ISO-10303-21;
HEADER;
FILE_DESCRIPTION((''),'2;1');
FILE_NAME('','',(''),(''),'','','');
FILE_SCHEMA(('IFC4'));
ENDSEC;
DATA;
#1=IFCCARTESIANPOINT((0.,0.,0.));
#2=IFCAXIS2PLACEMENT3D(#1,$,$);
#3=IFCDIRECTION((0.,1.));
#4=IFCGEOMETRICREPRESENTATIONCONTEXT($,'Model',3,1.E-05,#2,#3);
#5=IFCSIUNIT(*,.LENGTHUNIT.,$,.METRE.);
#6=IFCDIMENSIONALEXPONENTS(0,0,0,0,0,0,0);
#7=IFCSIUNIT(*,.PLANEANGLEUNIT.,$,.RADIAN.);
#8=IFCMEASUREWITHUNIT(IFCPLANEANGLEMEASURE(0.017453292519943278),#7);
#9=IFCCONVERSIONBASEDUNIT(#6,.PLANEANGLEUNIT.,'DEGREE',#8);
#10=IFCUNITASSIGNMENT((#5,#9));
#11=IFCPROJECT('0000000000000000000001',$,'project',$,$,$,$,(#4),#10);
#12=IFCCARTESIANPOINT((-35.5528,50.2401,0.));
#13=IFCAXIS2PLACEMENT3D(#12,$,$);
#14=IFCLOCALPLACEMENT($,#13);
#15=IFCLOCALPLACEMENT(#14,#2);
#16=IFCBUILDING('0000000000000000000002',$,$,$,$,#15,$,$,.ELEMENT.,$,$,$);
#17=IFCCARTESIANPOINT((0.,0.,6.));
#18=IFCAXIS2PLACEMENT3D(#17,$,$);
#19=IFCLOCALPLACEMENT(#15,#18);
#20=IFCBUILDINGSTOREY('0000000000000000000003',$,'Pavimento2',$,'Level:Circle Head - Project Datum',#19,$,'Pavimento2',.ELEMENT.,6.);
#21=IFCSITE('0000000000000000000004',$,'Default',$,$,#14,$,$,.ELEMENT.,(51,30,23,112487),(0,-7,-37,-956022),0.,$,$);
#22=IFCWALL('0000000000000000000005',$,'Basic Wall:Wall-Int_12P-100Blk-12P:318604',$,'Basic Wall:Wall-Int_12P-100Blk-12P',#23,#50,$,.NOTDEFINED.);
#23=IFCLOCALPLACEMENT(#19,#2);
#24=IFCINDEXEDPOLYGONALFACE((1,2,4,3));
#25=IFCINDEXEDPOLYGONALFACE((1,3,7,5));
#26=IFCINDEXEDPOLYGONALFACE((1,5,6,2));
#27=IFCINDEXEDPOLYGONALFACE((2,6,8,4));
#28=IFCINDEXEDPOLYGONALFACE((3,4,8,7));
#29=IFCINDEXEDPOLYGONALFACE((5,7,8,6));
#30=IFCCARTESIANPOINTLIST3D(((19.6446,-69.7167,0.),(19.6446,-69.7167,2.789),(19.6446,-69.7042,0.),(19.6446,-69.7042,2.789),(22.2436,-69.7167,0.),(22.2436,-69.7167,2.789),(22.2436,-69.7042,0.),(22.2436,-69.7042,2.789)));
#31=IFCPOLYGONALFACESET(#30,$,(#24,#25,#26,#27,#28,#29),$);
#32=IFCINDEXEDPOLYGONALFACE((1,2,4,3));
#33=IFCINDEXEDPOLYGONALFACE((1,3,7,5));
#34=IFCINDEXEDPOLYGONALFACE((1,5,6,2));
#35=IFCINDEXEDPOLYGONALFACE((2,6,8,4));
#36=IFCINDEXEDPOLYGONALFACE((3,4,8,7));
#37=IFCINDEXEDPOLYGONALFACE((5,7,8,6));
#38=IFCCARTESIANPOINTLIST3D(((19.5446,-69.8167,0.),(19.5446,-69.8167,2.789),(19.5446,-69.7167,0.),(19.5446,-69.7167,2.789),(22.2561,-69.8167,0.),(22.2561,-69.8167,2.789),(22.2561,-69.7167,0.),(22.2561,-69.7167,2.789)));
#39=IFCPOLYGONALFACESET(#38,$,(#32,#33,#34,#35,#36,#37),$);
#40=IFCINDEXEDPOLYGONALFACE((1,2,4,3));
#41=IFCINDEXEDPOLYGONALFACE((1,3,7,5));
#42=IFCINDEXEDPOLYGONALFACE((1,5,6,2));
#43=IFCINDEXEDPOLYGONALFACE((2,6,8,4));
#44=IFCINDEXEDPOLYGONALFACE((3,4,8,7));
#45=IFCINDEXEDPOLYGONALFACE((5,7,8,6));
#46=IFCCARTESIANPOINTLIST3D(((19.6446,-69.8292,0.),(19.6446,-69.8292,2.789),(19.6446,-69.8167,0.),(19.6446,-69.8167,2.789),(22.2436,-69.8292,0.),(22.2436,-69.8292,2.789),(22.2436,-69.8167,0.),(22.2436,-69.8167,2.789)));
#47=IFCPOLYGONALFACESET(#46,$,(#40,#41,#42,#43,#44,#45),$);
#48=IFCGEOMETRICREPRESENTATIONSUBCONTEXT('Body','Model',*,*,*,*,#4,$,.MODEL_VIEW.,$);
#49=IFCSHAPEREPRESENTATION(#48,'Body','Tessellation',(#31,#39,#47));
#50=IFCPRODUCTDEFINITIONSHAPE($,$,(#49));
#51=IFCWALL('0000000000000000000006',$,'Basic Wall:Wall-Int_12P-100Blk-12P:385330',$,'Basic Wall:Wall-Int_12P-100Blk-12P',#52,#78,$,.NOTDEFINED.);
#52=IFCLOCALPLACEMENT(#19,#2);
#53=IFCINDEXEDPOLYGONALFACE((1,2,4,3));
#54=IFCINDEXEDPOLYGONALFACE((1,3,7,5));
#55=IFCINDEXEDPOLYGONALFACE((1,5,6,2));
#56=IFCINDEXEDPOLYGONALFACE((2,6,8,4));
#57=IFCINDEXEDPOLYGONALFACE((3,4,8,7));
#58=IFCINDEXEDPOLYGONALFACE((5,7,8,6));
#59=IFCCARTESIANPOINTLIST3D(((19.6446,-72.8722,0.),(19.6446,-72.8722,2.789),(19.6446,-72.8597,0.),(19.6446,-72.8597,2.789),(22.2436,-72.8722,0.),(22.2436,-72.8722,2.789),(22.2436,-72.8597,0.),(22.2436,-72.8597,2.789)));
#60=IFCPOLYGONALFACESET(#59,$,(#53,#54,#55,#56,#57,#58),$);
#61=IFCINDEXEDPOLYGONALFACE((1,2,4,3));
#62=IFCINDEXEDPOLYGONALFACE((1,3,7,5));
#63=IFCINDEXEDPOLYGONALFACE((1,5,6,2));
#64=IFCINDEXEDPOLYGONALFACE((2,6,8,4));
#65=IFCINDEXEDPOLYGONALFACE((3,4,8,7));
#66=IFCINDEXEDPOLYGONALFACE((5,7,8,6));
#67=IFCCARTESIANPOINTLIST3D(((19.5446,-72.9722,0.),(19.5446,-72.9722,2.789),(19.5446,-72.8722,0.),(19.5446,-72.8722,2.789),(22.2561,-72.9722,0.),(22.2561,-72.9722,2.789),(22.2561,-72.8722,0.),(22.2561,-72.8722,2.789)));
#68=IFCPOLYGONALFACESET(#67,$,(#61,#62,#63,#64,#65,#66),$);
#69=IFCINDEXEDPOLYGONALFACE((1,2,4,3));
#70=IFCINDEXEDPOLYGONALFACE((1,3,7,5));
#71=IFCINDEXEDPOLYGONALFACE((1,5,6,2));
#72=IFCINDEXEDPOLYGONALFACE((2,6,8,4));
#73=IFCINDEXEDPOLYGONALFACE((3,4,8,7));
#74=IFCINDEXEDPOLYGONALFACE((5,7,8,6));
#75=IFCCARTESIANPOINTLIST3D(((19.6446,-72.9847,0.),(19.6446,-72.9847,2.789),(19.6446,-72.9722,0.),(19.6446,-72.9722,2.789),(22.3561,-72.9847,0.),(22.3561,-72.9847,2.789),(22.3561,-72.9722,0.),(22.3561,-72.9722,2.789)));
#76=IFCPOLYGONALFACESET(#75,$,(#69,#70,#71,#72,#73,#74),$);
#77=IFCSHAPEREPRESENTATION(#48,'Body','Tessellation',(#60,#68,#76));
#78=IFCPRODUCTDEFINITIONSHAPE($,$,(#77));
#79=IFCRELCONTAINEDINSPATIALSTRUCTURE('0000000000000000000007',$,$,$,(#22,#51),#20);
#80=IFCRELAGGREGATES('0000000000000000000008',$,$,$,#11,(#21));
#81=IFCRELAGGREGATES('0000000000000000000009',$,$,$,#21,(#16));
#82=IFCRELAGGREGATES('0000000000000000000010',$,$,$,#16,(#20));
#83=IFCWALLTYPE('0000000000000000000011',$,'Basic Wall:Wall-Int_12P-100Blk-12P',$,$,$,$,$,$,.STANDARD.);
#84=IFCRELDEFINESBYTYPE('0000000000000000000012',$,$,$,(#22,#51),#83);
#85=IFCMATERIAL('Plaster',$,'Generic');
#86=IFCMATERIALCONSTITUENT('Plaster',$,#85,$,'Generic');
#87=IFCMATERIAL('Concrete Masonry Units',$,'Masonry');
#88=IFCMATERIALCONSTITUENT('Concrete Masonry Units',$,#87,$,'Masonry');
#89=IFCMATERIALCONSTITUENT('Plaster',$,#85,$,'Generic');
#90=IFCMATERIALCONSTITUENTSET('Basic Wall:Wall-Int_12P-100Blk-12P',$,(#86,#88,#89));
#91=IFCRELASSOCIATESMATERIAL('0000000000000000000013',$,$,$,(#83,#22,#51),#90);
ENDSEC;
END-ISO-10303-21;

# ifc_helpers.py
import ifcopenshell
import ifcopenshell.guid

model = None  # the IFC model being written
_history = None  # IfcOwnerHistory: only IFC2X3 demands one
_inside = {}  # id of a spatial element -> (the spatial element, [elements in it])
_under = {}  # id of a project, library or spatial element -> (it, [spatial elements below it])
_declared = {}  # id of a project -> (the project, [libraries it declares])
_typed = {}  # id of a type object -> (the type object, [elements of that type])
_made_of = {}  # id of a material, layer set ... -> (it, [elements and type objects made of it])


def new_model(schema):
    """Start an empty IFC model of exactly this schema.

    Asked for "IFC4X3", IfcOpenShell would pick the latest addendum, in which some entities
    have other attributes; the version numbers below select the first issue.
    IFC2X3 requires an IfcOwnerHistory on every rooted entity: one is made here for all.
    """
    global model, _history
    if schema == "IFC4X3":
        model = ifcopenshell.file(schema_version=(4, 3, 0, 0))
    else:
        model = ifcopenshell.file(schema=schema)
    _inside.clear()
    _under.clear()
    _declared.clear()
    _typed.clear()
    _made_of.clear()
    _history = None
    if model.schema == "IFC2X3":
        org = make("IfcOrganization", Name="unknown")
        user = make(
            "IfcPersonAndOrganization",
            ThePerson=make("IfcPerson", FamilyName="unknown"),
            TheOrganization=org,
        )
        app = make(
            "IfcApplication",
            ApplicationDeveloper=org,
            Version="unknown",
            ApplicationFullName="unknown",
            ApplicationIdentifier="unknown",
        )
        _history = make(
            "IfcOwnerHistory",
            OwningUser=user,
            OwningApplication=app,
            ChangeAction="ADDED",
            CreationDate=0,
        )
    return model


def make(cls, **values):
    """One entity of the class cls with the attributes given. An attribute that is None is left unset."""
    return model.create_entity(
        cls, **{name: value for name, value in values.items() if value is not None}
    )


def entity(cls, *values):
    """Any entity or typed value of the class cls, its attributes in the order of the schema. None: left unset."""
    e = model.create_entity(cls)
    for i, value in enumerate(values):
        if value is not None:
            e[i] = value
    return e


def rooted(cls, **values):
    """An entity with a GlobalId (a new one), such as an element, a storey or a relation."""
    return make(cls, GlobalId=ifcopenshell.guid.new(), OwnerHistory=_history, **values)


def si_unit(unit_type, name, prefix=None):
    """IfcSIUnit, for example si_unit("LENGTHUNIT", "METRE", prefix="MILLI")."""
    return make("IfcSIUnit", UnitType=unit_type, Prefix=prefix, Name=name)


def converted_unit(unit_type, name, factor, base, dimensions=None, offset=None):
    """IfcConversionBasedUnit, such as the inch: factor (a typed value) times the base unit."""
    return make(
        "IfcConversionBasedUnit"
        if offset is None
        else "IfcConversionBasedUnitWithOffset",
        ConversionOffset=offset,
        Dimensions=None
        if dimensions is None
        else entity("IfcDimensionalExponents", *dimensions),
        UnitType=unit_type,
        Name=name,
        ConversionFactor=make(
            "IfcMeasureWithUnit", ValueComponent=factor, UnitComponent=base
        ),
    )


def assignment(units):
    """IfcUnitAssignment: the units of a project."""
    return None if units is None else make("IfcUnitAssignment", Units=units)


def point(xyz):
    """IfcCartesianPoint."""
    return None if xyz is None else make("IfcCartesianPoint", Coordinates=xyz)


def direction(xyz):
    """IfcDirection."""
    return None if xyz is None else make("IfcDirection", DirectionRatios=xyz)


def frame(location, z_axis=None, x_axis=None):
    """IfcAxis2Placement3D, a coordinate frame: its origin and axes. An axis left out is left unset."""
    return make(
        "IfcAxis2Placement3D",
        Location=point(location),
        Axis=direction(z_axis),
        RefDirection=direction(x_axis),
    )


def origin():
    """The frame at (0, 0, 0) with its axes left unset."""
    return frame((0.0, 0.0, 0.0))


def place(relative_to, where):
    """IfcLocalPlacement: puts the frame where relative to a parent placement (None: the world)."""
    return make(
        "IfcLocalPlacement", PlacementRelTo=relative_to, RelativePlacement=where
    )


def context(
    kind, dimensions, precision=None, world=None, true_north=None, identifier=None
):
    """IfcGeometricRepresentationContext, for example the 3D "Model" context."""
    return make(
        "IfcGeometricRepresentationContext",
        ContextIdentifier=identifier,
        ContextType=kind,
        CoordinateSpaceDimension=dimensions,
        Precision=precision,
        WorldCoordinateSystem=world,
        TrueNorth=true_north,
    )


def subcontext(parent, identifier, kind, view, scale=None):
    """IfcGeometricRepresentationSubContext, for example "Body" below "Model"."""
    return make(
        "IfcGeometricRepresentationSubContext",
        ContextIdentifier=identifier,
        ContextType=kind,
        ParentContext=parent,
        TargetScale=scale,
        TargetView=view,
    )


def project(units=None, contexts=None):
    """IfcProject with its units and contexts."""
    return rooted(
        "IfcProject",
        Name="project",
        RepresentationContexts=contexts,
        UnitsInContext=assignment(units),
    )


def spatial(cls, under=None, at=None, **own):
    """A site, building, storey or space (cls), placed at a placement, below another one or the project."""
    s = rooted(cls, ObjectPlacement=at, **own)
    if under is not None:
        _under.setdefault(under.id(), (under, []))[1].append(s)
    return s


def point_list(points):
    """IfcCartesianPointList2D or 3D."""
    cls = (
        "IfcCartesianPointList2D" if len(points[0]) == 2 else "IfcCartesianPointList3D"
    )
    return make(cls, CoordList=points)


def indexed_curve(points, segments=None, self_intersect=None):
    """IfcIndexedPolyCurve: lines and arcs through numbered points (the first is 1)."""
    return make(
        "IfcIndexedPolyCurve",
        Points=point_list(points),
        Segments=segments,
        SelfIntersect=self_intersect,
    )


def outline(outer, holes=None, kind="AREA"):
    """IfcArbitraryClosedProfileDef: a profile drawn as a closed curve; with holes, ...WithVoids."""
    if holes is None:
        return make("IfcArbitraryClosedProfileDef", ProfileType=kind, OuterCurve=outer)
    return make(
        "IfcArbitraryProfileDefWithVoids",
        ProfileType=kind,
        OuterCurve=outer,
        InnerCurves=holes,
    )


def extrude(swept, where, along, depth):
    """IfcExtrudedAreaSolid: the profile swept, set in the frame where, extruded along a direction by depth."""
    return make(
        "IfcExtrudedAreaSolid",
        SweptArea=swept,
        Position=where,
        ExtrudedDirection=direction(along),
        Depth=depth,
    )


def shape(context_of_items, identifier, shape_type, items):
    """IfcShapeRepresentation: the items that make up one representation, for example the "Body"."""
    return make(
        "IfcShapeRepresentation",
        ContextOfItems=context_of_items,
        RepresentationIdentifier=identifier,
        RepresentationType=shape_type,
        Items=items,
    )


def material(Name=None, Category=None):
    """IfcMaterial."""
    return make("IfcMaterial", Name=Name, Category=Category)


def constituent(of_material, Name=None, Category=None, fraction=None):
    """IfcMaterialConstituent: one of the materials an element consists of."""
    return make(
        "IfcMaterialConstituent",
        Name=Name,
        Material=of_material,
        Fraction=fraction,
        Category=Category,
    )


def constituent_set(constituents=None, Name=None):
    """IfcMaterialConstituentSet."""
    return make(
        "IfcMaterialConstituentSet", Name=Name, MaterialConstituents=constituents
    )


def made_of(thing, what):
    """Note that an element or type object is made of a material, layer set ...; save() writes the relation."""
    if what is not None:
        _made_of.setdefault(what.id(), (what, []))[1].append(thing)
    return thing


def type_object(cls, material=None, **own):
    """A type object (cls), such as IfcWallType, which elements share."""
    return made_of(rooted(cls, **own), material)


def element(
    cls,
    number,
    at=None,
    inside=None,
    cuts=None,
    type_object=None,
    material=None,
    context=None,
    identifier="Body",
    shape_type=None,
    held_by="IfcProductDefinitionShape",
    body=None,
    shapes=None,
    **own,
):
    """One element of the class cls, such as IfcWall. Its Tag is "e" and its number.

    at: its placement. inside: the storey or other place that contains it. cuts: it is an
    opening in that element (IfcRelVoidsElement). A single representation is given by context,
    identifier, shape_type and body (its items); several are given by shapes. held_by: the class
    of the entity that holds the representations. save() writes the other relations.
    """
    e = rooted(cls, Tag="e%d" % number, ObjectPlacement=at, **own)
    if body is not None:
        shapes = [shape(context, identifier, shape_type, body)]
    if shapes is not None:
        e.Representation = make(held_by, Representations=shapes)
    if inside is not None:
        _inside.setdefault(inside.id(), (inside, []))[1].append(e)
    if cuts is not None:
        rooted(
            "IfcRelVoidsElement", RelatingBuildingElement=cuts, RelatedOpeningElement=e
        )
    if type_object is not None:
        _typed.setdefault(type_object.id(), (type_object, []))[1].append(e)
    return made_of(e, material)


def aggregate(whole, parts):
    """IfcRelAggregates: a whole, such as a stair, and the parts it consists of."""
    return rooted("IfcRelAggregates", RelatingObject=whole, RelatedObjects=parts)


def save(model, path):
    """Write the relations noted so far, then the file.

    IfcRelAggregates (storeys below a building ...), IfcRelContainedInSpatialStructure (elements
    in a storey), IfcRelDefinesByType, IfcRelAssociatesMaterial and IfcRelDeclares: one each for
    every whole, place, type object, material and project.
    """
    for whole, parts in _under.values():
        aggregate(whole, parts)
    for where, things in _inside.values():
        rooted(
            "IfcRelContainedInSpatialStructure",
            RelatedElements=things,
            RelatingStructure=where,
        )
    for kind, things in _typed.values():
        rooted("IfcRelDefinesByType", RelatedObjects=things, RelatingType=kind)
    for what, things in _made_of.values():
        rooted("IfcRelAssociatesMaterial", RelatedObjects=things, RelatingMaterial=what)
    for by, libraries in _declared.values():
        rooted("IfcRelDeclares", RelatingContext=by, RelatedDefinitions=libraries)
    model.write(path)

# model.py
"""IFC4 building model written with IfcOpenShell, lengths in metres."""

from ifc_helpers import new_model, entity, si_unit, converted_unit, direction, frame, origin, place, context, subcontext, project, spatial, indexed_curve, outline, extrude, material, constituent, constituent_set, type_object, element, save


model = new_model("IFC4")

# Units and contexts
model_context = context("Model", 3, precision=1e-05, world=origin(), true_north=direction((0.0, 1.0)))
body_context = subcontext(model_context, "Body", "Model", "MODEL_VIEW")
ifc_project = project(units=[si_unit("LENGTHUNIT", "METRE"), converted_unit("PLANEANGLEUNIT", "DEGREE", entity("IfcPlaneAngleMeasure", 0.017453292519943278), si_unit("PLANEANGLEUNIT", "RADIAN"), dimensions=[0, 0, 0, 0, 0, 0, 0])], contexts=[model_context])

# Site, building, storey
site_placement = place(None, frame((-35.5528, 50.2401, 0.0)))
site = spatial("IfcSite", under=ifc_project, at=site_placement, Name="Default", CompositionType="ELEMENT", RefLatitude=(51, 30, 23, 112487), RefLongitude=(0, -7, -37, -956022), RefElevation=0.0)
building_placement = place(site_placement, origin())
building = spatial("IfcBuilding", under=site, at=building_placement, CompositionType="ELEMENT")
storey_placement = place(building_placement, frame((0.0, 0.0, 6.0)))
storey = spatial("IfcBuildingStorey", under=building, at=storey_placement, Name="Pavimento2", ObjectType="Level:Circle Head - Project Datum", LongName="Pavimento2", CompositionType="ELEMENT", Elevation=6.0)

# Shared definitions
ifc_material_1 = material(Name="Plaster", Category="Generic")

# Shared definitions
ifc_constituent_1 = constituent(ifc_material_1, Name="Plaster", Category="Generic")
ifc_material_2 = material(Name="Concrete Masonry Units", Category="Masonry")
ifc_constituent_2 = constituent(ifc_material_2, Name="Concrete Masonry Units", Category="Masonry")
ifc_constituent_3 = constituent(ifc_material_1, Name="Plaster", Category="Generic")
ifc_constituent_set_1 = constituent_set(constituents=[ifc_constituent_1, ifc_constituent_2, ifc_constituent_3], Name="Basic Wall:Wall-Int_12P-100Blk-12P")
wall_type_1 = type_object("IfcWallType", Name="Basic Wall:Wall-Int_12P-100Blk-12P", PredefinedType="STANDARD", material=ifc_constituent_set_1)

# Wall
wall_1_placement = place(storey_placement, frame((22.2436, -69.7667, 0.0), z_axis=(0.0, 0.0, 1.0), x_axis=(-1.0, 0.0, 0.0)))
element("IfcWall", 1, at=wall_1_placement, inside=storey, type_object=wall_type_1, material=ifc_constituent_set_1, Name="Basic Wall:Wall-Int_12P-100Blk-12P:318604", ObjectType="Basic Wall:Wall-Int_12P-100Blk-12P", PredefinedType="NOTDEFINED", context=body_context, shape_type="SweptSolid", body=[
    extrude(outline(indexed_curve([(-0.0063, -1.2995), (0.0062, -1.2995), (0.0062, 1.2995), (-0.0063, 1.2995), (-0.0063, -1.2995)], self_intersect=False)), frame((1.2995, -0.0562, 0.0), z_axis=(0.0, 0.0, 1.0), x_axis=(0.0, 1.0, 0.0)), (0.0, 0.0, 1.0), 2.789),
    extrude(outline(indexed_curve([(-1.3557, -0.05), (1.3558, -0.05), (1.3558, 0.05), (-1.3557, 0.05), (-1.3557, -0.05)], self_intersect=False)), frame((1.3432, 0.0, 0.0)), (0.0, 0.0, 1.0), 2.789),
    extrude(outline(indexed_curve([(-0.0063, -1.2995), (0.0063, -1.2995), (0.0063, 1.2995), (-0.0062, 1.2995), (-0.0063, -1.2995)], self_intersect=False)), frame((1.2995, 0.0563, 0.0), z_axis=(0.0, 0.0, 1.0), x_axis=(0.0, -1.0, 0.0)), (0.0, 0.0, 1.0), 2.789),
])

# Wall
wall_2_placement = place(storey_placement, frame((22.2436, -72.9222, 0.0), z_axis=(0.0, 0.0, 1.0), x_axis=(-1.0, 0.0, 0.0)))
element("IfcWall", 2, at=wall_2_placement, inside=storey, type_object=wall_type_1, material=ifc_constituent_set_1, Name="Basic Wall:Wall-Int_12P-100Blk-12P:385330", ObjectType="Basic Wall:Wall-Int_12P-100Blk-12P", PredefinedType="NOTDEFINED", context=body_context, shape_type="SweptSolid", body=[
    extrude(outline(indexed_curve([(-0.0063, -1.2995), (0.0062, -1.2995), (0.0063, 1.2995), (-0.0062, 1.2995), (-0.0063, -1.2995)], self_intersect=False)), frame((1.2995, -0.0563, 0.0), z_axis=(0.0, 0.0, 1.0), x_axis=(0.0, 1.0, 0.0)), (0.0, 0.0, 1.0), 2.789),
    extrude(outline(indexed_curve([(-1.3557, -0.05), (1.3557, -0.05), (1.3557, 0.05), (-1.3557, 0.05), (-1.3557, -0.05)], self_intersect=False)), frame((1.3433, 0.0, 0.0)), (0.0, 0.0, 1.0), 2.789),
    extrude(outline(indexed_curve([(-0.0063, -1.3557), (0.0063, -1.3557), (0.0063, 1.3557), (-0.0062, 1.3557), (-0.0063, -1.3557)], self_intersect=False)), frame((1.2433, 0.0563, 0.0), z_axis=(0.0, 0.0, 1.0), x_axis=(0.0, -1.0, 0.0)), (0.0, 0.0, 1.0), 2.789),
])

save(model, "model.ifc")
